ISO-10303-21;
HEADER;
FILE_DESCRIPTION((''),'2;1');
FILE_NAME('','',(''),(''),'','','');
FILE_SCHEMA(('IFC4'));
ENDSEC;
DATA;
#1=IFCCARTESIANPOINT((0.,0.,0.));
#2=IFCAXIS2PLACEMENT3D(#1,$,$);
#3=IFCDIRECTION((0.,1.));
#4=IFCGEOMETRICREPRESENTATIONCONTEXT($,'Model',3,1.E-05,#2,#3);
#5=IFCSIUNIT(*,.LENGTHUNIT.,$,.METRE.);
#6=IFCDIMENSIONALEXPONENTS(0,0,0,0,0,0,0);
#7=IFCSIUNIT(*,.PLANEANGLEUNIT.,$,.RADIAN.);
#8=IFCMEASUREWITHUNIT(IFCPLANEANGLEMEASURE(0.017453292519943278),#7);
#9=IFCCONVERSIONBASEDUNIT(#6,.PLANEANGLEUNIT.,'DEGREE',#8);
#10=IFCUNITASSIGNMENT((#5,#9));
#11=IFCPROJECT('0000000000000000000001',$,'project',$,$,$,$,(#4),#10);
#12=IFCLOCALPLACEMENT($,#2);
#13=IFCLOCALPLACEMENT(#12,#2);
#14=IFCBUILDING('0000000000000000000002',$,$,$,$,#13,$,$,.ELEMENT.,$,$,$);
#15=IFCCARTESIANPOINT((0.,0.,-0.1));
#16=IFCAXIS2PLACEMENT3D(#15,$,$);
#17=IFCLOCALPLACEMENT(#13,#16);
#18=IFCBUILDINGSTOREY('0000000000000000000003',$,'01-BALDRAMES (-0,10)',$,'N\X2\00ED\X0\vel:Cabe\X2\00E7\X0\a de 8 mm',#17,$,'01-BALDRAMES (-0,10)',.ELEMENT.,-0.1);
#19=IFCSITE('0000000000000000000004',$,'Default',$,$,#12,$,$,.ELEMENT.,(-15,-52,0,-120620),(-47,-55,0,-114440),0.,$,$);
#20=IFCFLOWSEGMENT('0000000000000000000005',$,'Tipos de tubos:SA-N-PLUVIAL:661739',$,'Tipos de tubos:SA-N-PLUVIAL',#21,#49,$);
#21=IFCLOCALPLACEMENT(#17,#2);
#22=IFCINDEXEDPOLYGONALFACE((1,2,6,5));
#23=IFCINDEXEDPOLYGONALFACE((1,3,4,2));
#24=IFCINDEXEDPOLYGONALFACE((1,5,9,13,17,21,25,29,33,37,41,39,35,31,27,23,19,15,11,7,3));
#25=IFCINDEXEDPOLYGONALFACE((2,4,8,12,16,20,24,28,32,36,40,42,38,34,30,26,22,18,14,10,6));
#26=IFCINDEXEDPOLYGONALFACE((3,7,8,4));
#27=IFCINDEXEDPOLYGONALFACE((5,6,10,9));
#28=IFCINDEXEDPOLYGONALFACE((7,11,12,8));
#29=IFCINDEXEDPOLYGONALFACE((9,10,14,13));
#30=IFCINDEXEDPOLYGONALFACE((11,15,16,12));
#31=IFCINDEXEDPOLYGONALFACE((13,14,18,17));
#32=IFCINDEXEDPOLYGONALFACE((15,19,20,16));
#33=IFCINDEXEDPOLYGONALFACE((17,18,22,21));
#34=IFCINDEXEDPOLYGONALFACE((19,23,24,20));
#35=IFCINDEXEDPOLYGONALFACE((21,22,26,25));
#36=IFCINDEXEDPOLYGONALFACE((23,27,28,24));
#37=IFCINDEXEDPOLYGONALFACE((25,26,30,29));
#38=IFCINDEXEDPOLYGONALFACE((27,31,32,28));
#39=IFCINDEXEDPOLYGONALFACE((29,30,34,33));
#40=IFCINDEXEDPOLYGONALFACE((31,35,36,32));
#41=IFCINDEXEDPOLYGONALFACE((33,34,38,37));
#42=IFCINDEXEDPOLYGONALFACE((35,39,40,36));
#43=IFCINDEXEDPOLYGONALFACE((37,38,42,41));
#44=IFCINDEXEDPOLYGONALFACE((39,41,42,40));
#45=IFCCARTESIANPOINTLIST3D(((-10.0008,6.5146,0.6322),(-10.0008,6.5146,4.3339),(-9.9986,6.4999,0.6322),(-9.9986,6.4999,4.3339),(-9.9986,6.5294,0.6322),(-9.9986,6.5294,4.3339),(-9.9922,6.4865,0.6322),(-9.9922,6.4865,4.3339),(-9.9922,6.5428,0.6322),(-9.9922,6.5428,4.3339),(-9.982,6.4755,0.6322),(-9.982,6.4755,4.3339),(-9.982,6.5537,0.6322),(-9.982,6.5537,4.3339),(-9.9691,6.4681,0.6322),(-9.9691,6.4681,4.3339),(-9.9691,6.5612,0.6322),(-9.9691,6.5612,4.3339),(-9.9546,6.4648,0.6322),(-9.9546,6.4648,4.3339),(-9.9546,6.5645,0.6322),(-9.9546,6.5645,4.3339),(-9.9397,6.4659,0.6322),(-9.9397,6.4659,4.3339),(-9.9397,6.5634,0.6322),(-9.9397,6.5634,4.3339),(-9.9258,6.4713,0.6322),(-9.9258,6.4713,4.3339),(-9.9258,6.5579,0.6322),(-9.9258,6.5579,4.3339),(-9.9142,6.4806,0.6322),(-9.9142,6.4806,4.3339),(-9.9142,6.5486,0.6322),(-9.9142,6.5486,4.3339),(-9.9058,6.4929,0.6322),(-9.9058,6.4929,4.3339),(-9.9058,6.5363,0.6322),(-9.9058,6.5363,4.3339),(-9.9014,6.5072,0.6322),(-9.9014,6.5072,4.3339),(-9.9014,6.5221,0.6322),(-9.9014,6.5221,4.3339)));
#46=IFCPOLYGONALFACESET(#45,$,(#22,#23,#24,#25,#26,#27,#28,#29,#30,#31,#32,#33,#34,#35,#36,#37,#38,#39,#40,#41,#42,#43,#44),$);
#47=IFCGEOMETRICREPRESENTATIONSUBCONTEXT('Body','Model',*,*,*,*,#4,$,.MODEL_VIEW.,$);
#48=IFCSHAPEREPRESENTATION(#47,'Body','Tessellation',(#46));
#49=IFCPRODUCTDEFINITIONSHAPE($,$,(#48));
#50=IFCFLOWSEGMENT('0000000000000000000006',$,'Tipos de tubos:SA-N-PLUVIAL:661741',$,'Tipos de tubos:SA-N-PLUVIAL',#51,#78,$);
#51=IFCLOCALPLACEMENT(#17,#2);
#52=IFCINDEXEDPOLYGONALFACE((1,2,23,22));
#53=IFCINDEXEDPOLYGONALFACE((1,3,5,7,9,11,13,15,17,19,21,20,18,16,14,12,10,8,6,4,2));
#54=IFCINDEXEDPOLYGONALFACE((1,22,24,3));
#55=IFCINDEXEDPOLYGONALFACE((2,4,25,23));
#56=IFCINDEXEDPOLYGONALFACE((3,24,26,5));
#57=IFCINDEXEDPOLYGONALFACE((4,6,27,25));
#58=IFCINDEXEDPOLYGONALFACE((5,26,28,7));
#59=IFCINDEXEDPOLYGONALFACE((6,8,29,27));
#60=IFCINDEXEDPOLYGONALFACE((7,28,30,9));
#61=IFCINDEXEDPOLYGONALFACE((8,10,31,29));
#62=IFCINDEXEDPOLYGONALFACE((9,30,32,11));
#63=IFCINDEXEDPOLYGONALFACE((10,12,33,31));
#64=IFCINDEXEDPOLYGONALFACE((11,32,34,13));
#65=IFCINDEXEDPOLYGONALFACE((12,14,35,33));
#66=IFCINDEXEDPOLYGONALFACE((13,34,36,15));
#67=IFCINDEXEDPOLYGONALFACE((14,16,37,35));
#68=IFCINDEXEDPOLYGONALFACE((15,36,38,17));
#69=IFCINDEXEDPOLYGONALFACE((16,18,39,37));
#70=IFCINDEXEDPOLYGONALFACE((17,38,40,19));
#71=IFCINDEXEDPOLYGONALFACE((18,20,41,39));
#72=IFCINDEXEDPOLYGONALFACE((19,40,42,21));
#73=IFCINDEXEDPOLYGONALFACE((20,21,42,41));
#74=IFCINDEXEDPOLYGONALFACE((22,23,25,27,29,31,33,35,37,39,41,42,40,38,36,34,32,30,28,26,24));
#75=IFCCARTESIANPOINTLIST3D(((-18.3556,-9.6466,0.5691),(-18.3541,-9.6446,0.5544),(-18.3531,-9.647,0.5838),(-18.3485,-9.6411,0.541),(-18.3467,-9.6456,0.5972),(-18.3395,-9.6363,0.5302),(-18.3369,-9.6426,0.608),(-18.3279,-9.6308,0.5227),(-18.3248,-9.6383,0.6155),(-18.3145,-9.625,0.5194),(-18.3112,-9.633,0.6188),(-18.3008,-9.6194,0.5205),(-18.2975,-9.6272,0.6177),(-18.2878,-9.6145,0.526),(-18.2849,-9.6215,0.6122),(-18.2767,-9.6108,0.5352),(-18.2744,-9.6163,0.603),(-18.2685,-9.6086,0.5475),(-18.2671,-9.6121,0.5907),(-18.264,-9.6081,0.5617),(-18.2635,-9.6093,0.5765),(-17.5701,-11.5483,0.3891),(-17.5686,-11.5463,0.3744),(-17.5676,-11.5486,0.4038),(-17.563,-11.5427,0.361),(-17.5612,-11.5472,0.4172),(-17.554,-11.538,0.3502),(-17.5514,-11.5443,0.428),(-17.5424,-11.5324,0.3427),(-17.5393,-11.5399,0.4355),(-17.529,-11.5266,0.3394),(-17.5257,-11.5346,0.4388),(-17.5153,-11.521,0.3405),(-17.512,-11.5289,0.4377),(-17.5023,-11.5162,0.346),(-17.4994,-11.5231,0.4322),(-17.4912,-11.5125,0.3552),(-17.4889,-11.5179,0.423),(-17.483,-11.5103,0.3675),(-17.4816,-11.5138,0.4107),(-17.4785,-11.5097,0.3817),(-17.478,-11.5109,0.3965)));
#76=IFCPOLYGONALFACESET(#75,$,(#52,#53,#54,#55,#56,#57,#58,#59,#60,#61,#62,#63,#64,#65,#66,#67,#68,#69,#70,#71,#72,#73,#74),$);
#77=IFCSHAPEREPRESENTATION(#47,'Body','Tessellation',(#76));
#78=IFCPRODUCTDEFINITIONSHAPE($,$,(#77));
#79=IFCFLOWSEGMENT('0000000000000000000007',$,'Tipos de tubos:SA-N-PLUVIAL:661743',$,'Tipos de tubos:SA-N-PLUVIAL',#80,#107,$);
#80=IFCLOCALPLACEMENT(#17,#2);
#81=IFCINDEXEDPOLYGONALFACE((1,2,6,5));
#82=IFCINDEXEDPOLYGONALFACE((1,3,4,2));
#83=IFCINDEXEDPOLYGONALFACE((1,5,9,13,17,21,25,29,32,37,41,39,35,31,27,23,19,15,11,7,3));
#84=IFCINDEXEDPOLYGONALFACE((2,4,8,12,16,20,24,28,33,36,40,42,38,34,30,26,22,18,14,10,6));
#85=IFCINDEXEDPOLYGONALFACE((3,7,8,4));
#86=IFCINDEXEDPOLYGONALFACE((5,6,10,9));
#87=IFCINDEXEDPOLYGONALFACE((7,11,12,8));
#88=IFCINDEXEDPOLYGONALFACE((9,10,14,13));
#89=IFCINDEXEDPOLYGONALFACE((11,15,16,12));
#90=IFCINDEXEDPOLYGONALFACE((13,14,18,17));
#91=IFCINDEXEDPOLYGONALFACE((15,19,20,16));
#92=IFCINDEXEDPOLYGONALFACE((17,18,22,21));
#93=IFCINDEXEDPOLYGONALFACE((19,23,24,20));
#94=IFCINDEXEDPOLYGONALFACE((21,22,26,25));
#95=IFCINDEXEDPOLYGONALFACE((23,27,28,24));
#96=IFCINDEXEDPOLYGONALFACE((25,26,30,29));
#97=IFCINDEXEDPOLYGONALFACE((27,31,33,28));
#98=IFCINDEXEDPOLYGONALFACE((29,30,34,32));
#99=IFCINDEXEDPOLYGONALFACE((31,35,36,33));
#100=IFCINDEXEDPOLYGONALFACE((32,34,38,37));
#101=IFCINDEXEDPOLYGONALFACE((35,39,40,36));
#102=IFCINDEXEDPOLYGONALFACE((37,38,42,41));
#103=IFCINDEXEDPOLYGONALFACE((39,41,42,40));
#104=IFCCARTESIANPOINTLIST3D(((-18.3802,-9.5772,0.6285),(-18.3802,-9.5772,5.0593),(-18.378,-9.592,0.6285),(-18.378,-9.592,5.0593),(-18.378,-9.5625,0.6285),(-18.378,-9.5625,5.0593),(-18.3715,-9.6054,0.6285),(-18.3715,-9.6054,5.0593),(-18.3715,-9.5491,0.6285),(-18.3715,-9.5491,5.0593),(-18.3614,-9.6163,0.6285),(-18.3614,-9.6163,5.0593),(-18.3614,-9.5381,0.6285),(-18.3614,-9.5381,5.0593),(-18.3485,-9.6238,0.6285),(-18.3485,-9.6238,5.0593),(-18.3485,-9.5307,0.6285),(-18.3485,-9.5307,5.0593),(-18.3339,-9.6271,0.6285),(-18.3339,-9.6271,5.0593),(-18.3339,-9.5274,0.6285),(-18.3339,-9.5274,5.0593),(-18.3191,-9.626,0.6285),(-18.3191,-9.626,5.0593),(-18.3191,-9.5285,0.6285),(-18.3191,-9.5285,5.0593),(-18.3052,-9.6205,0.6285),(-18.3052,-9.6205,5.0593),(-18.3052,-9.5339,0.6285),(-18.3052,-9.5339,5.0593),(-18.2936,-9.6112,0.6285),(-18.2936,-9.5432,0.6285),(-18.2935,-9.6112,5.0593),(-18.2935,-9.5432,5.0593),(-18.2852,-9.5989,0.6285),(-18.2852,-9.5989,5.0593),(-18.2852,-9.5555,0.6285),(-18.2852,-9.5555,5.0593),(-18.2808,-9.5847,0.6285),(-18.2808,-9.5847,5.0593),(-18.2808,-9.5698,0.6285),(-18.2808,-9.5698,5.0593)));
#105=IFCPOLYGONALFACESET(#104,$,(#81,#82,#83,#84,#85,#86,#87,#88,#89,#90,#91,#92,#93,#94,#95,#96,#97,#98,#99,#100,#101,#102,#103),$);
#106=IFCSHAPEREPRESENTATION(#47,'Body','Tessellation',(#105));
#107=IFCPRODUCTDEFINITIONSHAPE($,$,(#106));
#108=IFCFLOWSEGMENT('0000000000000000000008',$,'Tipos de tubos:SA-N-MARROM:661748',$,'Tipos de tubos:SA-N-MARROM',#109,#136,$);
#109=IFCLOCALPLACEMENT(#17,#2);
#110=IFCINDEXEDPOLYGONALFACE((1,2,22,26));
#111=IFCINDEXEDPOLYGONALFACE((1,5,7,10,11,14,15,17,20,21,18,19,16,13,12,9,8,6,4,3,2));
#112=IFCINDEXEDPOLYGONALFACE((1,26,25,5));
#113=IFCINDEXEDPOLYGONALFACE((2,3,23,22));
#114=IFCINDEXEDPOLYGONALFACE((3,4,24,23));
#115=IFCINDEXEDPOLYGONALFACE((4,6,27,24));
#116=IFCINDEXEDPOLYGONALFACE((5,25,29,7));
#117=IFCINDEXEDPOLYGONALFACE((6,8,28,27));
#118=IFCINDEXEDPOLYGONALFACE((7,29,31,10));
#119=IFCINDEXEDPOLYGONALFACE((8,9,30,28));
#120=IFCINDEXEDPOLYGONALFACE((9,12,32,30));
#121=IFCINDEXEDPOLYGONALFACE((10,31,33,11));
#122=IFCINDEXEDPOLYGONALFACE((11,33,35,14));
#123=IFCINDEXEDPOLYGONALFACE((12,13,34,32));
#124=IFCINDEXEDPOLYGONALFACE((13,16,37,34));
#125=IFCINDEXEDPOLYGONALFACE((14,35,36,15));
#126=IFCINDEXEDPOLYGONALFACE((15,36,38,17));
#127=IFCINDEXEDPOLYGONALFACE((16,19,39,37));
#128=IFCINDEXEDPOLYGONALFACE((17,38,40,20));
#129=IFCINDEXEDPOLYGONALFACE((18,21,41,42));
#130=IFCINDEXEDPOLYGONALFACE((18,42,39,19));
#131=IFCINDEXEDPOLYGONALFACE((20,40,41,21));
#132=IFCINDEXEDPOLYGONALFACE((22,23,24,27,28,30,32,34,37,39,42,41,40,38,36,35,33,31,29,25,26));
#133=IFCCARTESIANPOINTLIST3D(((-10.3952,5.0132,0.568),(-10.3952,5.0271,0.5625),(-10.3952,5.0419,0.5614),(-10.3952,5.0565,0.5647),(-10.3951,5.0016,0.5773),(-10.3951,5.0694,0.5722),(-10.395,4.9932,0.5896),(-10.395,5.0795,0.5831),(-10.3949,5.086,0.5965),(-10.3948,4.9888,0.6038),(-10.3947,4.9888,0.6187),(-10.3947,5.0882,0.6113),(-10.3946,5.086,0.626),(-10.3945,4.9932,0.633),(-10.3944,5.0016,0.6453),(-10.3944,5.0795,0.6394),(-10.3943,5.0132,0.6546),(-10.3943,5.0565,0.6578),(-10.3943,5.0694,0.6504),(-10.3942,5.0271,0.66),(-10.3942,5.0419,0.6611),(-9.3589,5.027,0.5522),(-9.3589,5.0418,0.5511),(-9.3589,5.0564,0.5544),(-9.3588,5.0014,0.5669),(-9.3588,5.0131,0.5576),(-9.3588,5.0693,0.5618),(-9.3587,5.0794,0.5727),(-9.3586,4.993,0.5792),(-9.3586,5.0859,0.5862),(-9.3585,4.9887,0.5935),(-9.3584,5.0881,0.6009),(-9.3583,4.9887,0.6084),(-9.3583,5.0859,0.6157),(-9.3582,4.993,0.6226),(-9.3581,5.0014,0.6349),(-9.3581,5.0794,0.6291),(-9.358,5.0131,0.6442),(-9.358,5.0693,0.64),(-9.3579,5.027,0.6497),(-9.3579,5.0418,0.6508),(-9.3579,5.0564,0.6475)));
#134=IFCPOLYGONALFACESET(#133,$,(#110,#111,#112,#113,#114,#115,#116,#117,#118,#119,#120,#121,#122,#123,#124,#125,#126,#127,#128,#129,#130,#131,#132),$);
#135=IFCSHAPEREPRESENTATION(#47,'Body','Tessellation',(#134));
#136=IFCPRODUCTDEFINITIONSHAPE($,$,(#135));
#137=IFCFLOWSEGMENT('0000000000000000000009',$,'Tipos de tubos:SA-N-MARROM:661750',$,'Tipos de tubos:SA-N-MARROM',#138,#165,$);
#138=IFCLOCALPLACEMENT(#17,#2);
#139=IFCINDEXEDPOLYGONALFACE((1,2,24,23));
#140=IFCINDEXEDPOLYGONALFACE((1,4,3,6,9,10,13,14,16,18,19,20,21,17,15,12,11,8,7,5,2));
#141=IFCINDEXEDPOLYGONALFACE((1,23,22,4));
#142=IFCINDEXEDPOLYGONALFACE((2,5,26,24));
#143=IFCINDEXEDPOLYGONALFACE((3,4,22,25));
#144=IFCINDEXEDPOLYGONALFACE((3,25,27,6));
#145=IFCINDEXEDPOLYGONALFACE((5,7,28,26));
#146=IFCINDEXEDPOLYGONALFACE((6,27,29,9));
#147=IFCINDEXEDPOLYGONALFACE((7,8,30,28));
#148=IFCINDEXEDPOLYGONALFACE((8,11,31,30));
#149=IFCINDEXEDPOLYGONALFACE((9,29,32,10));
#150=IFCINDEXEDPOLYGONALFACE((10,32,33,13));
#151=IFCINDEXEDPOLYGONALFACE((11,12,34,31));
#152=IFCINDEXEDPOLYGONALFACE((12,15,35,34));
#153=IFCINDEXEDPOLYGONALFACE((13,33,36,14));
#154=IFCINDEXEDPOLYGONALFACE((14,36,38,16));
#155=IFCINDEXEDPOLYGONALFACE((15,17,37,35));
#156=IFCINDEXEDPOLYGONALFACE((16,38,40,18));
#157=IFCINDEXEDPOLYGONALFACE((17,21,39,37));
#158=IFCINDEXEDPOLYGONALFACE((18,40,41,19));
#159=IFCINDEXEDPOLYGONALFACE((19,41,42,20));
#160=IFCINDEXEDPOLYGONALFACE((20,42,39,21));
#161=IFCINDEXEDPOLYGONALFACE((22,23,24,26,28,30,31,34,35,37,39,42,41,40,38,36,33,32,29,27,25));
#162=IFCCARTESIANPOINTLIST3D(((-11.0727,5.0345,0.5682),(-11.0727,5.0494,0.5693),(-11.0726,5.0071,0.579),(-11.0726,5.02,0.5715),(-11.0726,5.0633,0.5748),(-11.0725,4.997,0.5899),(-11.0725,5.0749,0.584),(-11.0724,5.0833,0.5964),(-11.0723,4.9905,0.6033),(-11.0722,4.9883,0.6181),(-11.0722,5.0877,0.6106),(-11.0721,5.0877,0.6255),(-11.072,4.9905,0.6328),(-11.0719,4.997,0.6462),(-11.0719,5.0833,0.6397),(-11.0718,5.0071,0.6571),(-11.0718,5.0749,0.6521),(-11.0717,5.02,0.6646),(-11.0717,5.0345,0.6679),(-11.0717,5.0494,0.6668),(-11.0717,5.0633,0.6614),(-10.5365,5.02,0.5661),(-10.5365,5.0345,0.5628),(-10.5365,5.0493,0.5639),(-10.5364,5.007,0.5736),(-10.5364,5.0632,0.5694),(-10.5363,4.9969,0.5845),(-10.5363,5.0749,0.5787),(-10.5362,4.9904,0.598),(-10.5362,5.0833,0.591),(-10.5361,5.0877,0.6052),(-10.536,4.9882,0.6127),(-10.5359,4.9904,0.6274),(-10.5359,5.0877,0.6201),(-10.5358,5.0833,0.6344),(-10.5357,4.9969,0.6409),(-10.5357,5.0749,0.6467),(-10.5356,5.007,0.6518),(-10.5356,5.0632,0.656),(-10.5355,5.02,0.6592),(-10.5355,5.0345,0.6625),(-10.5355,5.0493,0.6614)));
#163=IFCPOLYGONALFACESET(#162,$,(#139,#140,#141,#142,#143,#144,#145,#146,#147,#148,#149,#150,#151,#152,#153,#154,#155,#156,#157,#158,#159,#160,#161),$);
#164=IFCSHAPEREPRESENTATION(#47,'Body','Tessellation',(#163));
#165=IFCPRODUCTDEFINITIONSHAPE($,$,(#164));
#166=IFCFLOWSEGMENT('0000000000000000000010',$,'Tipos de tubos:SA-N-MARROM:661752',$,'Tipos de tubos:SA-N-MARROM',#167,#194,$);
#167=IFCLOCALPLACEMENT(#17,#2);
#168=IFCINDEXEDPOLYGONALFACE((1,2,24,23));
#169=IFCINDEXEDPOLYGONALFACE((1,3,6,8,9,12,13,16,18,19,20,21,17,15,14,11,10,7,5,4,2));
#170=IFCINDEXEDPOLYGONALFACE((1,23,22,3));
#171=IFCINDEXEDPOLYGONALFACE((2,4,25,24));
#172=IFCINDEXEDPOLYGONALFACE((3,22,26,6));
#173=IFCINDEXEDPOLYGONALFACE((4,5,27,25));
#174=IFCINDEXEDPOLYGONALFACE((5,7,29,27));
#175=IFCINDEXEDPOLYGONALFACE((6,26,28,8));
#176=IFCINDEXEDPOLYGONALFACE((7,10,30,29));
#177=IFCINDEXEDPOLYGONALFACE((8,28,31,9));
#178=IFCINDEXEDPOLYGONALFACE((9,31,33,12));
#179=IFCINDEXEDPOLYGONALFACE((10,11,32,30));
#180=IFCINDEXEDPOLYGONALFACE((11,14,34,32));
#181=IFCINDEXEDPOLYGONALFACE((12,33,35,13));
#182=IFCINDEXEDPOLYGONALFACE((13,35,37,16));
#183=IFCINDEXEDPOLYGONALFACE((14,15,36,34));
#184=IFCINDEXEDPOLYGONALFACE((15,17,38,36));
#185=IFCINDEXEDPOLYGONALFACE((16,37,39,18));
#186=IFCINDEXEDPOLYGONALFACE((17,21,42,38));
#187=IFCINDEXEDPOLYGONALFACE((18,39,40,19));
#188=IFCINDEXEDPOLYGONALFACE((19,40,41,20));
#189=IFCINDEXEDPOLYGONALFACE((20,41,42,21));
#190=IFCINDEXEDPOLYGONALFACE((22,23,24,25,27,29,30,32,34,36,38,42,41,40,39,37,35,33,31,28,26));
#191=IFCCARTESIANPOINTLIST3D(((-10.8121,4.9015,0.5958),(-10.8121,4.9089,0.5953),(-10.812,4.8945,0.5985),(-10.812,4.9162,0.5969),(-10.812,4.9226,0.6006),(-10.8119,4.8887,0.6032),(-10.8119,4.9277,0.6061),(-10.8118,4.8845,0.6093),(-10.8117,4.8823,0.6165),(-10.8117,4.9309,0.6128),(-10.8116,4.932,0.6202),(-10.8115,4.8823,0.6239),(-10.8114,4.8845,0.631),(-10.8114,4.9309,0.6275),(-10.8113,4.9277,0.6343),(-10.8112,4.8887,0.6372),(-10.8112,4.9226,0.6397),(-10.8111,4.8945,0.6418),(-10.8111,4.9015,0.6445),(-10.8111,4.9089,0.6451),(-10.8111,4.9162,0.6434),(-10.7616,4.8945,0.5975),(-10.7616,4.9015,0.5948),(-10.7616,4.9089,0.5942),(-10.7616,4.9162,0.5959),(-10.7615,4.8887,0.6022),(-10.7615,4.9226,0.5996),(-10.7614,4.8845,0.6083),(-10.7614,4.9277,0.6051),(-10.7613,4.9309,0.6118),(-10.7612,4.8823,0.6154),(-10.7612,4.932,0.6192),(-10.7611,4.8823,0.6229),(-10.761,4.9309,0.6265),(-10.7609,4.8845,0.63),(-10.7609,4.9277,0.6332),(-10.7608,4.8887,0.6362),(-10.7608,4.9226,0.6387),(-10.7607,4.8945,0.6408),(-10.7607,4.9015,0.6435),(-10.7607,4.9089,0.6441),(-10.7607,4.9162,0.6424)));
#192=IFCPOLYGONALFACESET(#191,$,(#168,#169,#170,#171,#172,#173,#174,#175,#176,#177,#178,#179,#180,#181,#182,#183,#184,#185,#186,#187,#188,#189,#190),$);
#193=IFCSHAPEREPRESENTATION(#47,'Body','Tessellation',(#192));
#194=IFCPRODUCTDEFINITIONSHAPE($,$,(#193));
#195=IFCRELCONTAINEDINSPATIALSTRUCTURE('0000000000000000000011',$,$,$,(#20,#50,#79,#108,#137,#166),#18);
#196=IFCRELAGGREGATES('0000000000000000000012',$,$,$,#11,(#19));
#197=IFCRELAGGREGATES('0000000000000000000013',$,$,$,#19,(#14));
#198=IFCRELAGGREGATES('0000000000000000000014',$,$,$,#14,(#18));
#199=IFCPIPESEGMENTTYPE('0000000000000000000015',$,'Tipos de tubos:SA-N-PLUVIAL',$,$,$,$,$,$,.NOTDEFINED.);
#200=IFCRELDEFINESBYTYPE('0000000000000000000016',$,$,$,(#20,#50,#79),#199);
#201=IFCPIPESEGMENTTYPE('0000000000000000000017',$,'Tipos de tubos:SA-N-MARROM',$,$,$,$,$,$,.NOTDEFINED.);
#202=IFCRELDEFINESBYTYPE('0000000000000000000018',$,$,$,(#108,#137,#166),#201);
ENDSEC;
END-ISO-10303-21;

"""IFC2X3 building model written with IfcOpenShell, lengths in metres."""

from ifc_helpers import new_model, entity, si_unit, converted_unit, direction, frame, frame_2d, origin, origin_2d_with_axis, place, context, subcontext, project, spatial, circle, extrude, type_object, element, save


model = new_model("IFC2X3")

# Units and contexts
model_context = context("Model", 3, precision=1e-05, world=origin(), true_north=direction((0.0, 1.0)))
body_context = subcontext(model_context, "Body", "Model", "MODEL_VIEW")
ifc_project = project(units=[si_unit("LENGTHUNIT", "METRE"), converted_unit("PLANEANGLEUNIT", "DEGREE", entity("IfcPlaneAngleMeasure", 0.017453292519943278), si_unit("PLANEANGLEUNIT", "RADIAN"), dimensions=[0, 0, 0, 0, 0, 0, 0])], contexts=[model_context])

# Site, building, storey
site_placement = place(None, origin())
site = spatial("IfcSite", under=ifc_project, at=site_placement, Name="Default", CompositionType="ELEMENT", RefLatitude=(-15, -52, 0, -120620), RefLongitude=(-47, -55, 0, -114440), RefElevation=0.0)
building_placement = place(site_placement, origin())
building = spatial("IfcBuilding", under=site, at=building_placement, CompositionType="ELEMENT")
storey_placement = place(building_placement, frame((0.0, 0.0, -0.1)))
storey = spatial("IfcBuildingStorey", under=building, at=storey_placement, Name="01-BALDRAMES (-0,10)", ObjectType="Nível:Cabeça de 8 mm", LongName="01-BALDRAMES (-0,10)", CompositionType="ELEMENT", Elevation=-0.1)

# Flow segments
pipe_segment_type_1 = type_object("IfcPipeSegmentType", Name="Tipos de tubos:SA-N-PLUVIAL", PredefinedType="NOTDEFINED")
flow_segment_1_placement = place(storey_placement, origin())
element("IfcFlowSegment", 1, at=flow_segment_1_placement, inside=storey, type_object=pipe_segment_type_1, Name="Tipos de tubos:SA-N-PLUVIAL:661739", ObjectType="Tipos de tubos:SA-N-PLUVIAL", context=body_context, shape_type="SweptSolid", body=[
    extrude(circle(Radius=0.05, at=frame_2d((0.0, 0.0), x_axis=(1.0, 0.0))), frame((-9.9508, 6.5146, 0.6322), z_axis=(0.000001, 0.0, 1.0), x_axis=(-1.0, 0.0, 0.000001)), (0.0, 0.0, 1.0), 3.7016),
])
flow_segment_2_placement = place(storey_placement, origin())
element("IfcFlowSegment", 2, at=flow_segment_2_placement, inside=storey, type_object=pipe_segment_type_1, Name="Tipos de tubos:SA-N-PLUVIAL:661741", ObjectType="Tipos de tubos:SA-N-PLUVIAL", context=body_context, shape_type="SweptSolid", body=[
    extrude(circle(Radius=0.05, at=frame_2d((0.0, 0.0), x_axis=(1.0, 0.0))), frame((-17.5239, -11.5292, 0.3891), z_axis=(-0.380322, 0.920738, 0.087156), x_axis=(-0.924255, -0.381775, 0.0)), (0.0, 0.0, 1.0), 2.0654),
])
flow_segment_3_placement = place(storey_placement, origin())
element("IfcFlowSegment", 3, at=flow_segment_3_placement, inside=storey, type_object=pipe_segment_type_1, Name="Tipos de tubos:SA-N-PLUVIAL:661743", ObjectType="Tipos de tubos:SA-N-PLUVIAL", context=body_context, shape_type="SweptSolid", body=[
    extrude(circle(Radius=0.05, at=origin_2d_with_axis()), frame((-18.3302, -9.5772, 0.6285), z_axis=(0.000001, -0.000001, 1.0), x_axis=(-1.0, 0.0, 0.000001)), (0.0, 0.0, 1.0), 4.4308),
])
pipe_segment_type_2 = type_object("IfcPipeSegmentType", Name="Tipos de tubos:SA-N-MARROM", PredefinedType="NOTDEFINED")
flow_segment_4_placement = place(storey_placement, origin())
element("IfcFlowSegment", 4, at=flow_segment_4_placement, inside=storey, type_object=pipe_segment_type_2, Name="Tipos de tubos:SA-N-MARROM:661748", ObjectType="Tipos de tubos:SA-N-MARROM", context=body_context, shape_type="SweptSolid", body=[
    extrude(circle(Radius=0.05, at=frame_2d((0.0, 0.0), x_axis=(1.0, 0.0))), frame((-10.3947, 5.0382, 0.6113), z_axis=(0.99995, -0.000103, -0.01), x_axis=(0.000103, 1.0, 0.0)), (0.0, 0.0, 1.0), 1.0364),
])
flow_segment_5_placement = place(storey_placement, origin())
element("IfcFlowSegment", 5, at=flow_segment_5_placement, inside=storey, type_object=pipe_segment_type_2, Name="Tipos de tubos:SA-N-MARROM:661750", ObjectType="Tipos de tubos:SA-N-MARROM", context=body_context, shape_type="SweptSolid", body=[
    extrude(circle(Radius=0.05, at=frame_2d((0.0, 0.0), x_axis=(1.0, 0.0))), frame((-11.0722, 5.0383, 0.6181), z_axis=(0.99995, -0.000103, -0.01), x_axis=(-0.000103, -1.0, 0.0)), (0.0, 0.0, 1.0), 0.5362),
])
flow_segment_6_placement = place(storey_placement, origin())
element("IfcFlowSegment", 6, at=flow_segment_6_placement, inside=storey, type_object=pipe_segment_type_2, Name="Tipos de tubos:SA-N-MARROM:661752", ObjectType="Tipos de tubos:SA-N-MARROM", context=body_context, shape_type="SweptSolid", body=[
    extrude(circle(Radius=0.025, at=origin_2d_with_axis()), frame((-10.8116, 4.907, 0.6202), z_axis=(0.9998, 0.000001, -0.019996), x_axis=(-0.000001, 1.0, 0.0)), (0.0, 0.0, 1.0), 0.0504),
])

save(model, "model.ifc")
